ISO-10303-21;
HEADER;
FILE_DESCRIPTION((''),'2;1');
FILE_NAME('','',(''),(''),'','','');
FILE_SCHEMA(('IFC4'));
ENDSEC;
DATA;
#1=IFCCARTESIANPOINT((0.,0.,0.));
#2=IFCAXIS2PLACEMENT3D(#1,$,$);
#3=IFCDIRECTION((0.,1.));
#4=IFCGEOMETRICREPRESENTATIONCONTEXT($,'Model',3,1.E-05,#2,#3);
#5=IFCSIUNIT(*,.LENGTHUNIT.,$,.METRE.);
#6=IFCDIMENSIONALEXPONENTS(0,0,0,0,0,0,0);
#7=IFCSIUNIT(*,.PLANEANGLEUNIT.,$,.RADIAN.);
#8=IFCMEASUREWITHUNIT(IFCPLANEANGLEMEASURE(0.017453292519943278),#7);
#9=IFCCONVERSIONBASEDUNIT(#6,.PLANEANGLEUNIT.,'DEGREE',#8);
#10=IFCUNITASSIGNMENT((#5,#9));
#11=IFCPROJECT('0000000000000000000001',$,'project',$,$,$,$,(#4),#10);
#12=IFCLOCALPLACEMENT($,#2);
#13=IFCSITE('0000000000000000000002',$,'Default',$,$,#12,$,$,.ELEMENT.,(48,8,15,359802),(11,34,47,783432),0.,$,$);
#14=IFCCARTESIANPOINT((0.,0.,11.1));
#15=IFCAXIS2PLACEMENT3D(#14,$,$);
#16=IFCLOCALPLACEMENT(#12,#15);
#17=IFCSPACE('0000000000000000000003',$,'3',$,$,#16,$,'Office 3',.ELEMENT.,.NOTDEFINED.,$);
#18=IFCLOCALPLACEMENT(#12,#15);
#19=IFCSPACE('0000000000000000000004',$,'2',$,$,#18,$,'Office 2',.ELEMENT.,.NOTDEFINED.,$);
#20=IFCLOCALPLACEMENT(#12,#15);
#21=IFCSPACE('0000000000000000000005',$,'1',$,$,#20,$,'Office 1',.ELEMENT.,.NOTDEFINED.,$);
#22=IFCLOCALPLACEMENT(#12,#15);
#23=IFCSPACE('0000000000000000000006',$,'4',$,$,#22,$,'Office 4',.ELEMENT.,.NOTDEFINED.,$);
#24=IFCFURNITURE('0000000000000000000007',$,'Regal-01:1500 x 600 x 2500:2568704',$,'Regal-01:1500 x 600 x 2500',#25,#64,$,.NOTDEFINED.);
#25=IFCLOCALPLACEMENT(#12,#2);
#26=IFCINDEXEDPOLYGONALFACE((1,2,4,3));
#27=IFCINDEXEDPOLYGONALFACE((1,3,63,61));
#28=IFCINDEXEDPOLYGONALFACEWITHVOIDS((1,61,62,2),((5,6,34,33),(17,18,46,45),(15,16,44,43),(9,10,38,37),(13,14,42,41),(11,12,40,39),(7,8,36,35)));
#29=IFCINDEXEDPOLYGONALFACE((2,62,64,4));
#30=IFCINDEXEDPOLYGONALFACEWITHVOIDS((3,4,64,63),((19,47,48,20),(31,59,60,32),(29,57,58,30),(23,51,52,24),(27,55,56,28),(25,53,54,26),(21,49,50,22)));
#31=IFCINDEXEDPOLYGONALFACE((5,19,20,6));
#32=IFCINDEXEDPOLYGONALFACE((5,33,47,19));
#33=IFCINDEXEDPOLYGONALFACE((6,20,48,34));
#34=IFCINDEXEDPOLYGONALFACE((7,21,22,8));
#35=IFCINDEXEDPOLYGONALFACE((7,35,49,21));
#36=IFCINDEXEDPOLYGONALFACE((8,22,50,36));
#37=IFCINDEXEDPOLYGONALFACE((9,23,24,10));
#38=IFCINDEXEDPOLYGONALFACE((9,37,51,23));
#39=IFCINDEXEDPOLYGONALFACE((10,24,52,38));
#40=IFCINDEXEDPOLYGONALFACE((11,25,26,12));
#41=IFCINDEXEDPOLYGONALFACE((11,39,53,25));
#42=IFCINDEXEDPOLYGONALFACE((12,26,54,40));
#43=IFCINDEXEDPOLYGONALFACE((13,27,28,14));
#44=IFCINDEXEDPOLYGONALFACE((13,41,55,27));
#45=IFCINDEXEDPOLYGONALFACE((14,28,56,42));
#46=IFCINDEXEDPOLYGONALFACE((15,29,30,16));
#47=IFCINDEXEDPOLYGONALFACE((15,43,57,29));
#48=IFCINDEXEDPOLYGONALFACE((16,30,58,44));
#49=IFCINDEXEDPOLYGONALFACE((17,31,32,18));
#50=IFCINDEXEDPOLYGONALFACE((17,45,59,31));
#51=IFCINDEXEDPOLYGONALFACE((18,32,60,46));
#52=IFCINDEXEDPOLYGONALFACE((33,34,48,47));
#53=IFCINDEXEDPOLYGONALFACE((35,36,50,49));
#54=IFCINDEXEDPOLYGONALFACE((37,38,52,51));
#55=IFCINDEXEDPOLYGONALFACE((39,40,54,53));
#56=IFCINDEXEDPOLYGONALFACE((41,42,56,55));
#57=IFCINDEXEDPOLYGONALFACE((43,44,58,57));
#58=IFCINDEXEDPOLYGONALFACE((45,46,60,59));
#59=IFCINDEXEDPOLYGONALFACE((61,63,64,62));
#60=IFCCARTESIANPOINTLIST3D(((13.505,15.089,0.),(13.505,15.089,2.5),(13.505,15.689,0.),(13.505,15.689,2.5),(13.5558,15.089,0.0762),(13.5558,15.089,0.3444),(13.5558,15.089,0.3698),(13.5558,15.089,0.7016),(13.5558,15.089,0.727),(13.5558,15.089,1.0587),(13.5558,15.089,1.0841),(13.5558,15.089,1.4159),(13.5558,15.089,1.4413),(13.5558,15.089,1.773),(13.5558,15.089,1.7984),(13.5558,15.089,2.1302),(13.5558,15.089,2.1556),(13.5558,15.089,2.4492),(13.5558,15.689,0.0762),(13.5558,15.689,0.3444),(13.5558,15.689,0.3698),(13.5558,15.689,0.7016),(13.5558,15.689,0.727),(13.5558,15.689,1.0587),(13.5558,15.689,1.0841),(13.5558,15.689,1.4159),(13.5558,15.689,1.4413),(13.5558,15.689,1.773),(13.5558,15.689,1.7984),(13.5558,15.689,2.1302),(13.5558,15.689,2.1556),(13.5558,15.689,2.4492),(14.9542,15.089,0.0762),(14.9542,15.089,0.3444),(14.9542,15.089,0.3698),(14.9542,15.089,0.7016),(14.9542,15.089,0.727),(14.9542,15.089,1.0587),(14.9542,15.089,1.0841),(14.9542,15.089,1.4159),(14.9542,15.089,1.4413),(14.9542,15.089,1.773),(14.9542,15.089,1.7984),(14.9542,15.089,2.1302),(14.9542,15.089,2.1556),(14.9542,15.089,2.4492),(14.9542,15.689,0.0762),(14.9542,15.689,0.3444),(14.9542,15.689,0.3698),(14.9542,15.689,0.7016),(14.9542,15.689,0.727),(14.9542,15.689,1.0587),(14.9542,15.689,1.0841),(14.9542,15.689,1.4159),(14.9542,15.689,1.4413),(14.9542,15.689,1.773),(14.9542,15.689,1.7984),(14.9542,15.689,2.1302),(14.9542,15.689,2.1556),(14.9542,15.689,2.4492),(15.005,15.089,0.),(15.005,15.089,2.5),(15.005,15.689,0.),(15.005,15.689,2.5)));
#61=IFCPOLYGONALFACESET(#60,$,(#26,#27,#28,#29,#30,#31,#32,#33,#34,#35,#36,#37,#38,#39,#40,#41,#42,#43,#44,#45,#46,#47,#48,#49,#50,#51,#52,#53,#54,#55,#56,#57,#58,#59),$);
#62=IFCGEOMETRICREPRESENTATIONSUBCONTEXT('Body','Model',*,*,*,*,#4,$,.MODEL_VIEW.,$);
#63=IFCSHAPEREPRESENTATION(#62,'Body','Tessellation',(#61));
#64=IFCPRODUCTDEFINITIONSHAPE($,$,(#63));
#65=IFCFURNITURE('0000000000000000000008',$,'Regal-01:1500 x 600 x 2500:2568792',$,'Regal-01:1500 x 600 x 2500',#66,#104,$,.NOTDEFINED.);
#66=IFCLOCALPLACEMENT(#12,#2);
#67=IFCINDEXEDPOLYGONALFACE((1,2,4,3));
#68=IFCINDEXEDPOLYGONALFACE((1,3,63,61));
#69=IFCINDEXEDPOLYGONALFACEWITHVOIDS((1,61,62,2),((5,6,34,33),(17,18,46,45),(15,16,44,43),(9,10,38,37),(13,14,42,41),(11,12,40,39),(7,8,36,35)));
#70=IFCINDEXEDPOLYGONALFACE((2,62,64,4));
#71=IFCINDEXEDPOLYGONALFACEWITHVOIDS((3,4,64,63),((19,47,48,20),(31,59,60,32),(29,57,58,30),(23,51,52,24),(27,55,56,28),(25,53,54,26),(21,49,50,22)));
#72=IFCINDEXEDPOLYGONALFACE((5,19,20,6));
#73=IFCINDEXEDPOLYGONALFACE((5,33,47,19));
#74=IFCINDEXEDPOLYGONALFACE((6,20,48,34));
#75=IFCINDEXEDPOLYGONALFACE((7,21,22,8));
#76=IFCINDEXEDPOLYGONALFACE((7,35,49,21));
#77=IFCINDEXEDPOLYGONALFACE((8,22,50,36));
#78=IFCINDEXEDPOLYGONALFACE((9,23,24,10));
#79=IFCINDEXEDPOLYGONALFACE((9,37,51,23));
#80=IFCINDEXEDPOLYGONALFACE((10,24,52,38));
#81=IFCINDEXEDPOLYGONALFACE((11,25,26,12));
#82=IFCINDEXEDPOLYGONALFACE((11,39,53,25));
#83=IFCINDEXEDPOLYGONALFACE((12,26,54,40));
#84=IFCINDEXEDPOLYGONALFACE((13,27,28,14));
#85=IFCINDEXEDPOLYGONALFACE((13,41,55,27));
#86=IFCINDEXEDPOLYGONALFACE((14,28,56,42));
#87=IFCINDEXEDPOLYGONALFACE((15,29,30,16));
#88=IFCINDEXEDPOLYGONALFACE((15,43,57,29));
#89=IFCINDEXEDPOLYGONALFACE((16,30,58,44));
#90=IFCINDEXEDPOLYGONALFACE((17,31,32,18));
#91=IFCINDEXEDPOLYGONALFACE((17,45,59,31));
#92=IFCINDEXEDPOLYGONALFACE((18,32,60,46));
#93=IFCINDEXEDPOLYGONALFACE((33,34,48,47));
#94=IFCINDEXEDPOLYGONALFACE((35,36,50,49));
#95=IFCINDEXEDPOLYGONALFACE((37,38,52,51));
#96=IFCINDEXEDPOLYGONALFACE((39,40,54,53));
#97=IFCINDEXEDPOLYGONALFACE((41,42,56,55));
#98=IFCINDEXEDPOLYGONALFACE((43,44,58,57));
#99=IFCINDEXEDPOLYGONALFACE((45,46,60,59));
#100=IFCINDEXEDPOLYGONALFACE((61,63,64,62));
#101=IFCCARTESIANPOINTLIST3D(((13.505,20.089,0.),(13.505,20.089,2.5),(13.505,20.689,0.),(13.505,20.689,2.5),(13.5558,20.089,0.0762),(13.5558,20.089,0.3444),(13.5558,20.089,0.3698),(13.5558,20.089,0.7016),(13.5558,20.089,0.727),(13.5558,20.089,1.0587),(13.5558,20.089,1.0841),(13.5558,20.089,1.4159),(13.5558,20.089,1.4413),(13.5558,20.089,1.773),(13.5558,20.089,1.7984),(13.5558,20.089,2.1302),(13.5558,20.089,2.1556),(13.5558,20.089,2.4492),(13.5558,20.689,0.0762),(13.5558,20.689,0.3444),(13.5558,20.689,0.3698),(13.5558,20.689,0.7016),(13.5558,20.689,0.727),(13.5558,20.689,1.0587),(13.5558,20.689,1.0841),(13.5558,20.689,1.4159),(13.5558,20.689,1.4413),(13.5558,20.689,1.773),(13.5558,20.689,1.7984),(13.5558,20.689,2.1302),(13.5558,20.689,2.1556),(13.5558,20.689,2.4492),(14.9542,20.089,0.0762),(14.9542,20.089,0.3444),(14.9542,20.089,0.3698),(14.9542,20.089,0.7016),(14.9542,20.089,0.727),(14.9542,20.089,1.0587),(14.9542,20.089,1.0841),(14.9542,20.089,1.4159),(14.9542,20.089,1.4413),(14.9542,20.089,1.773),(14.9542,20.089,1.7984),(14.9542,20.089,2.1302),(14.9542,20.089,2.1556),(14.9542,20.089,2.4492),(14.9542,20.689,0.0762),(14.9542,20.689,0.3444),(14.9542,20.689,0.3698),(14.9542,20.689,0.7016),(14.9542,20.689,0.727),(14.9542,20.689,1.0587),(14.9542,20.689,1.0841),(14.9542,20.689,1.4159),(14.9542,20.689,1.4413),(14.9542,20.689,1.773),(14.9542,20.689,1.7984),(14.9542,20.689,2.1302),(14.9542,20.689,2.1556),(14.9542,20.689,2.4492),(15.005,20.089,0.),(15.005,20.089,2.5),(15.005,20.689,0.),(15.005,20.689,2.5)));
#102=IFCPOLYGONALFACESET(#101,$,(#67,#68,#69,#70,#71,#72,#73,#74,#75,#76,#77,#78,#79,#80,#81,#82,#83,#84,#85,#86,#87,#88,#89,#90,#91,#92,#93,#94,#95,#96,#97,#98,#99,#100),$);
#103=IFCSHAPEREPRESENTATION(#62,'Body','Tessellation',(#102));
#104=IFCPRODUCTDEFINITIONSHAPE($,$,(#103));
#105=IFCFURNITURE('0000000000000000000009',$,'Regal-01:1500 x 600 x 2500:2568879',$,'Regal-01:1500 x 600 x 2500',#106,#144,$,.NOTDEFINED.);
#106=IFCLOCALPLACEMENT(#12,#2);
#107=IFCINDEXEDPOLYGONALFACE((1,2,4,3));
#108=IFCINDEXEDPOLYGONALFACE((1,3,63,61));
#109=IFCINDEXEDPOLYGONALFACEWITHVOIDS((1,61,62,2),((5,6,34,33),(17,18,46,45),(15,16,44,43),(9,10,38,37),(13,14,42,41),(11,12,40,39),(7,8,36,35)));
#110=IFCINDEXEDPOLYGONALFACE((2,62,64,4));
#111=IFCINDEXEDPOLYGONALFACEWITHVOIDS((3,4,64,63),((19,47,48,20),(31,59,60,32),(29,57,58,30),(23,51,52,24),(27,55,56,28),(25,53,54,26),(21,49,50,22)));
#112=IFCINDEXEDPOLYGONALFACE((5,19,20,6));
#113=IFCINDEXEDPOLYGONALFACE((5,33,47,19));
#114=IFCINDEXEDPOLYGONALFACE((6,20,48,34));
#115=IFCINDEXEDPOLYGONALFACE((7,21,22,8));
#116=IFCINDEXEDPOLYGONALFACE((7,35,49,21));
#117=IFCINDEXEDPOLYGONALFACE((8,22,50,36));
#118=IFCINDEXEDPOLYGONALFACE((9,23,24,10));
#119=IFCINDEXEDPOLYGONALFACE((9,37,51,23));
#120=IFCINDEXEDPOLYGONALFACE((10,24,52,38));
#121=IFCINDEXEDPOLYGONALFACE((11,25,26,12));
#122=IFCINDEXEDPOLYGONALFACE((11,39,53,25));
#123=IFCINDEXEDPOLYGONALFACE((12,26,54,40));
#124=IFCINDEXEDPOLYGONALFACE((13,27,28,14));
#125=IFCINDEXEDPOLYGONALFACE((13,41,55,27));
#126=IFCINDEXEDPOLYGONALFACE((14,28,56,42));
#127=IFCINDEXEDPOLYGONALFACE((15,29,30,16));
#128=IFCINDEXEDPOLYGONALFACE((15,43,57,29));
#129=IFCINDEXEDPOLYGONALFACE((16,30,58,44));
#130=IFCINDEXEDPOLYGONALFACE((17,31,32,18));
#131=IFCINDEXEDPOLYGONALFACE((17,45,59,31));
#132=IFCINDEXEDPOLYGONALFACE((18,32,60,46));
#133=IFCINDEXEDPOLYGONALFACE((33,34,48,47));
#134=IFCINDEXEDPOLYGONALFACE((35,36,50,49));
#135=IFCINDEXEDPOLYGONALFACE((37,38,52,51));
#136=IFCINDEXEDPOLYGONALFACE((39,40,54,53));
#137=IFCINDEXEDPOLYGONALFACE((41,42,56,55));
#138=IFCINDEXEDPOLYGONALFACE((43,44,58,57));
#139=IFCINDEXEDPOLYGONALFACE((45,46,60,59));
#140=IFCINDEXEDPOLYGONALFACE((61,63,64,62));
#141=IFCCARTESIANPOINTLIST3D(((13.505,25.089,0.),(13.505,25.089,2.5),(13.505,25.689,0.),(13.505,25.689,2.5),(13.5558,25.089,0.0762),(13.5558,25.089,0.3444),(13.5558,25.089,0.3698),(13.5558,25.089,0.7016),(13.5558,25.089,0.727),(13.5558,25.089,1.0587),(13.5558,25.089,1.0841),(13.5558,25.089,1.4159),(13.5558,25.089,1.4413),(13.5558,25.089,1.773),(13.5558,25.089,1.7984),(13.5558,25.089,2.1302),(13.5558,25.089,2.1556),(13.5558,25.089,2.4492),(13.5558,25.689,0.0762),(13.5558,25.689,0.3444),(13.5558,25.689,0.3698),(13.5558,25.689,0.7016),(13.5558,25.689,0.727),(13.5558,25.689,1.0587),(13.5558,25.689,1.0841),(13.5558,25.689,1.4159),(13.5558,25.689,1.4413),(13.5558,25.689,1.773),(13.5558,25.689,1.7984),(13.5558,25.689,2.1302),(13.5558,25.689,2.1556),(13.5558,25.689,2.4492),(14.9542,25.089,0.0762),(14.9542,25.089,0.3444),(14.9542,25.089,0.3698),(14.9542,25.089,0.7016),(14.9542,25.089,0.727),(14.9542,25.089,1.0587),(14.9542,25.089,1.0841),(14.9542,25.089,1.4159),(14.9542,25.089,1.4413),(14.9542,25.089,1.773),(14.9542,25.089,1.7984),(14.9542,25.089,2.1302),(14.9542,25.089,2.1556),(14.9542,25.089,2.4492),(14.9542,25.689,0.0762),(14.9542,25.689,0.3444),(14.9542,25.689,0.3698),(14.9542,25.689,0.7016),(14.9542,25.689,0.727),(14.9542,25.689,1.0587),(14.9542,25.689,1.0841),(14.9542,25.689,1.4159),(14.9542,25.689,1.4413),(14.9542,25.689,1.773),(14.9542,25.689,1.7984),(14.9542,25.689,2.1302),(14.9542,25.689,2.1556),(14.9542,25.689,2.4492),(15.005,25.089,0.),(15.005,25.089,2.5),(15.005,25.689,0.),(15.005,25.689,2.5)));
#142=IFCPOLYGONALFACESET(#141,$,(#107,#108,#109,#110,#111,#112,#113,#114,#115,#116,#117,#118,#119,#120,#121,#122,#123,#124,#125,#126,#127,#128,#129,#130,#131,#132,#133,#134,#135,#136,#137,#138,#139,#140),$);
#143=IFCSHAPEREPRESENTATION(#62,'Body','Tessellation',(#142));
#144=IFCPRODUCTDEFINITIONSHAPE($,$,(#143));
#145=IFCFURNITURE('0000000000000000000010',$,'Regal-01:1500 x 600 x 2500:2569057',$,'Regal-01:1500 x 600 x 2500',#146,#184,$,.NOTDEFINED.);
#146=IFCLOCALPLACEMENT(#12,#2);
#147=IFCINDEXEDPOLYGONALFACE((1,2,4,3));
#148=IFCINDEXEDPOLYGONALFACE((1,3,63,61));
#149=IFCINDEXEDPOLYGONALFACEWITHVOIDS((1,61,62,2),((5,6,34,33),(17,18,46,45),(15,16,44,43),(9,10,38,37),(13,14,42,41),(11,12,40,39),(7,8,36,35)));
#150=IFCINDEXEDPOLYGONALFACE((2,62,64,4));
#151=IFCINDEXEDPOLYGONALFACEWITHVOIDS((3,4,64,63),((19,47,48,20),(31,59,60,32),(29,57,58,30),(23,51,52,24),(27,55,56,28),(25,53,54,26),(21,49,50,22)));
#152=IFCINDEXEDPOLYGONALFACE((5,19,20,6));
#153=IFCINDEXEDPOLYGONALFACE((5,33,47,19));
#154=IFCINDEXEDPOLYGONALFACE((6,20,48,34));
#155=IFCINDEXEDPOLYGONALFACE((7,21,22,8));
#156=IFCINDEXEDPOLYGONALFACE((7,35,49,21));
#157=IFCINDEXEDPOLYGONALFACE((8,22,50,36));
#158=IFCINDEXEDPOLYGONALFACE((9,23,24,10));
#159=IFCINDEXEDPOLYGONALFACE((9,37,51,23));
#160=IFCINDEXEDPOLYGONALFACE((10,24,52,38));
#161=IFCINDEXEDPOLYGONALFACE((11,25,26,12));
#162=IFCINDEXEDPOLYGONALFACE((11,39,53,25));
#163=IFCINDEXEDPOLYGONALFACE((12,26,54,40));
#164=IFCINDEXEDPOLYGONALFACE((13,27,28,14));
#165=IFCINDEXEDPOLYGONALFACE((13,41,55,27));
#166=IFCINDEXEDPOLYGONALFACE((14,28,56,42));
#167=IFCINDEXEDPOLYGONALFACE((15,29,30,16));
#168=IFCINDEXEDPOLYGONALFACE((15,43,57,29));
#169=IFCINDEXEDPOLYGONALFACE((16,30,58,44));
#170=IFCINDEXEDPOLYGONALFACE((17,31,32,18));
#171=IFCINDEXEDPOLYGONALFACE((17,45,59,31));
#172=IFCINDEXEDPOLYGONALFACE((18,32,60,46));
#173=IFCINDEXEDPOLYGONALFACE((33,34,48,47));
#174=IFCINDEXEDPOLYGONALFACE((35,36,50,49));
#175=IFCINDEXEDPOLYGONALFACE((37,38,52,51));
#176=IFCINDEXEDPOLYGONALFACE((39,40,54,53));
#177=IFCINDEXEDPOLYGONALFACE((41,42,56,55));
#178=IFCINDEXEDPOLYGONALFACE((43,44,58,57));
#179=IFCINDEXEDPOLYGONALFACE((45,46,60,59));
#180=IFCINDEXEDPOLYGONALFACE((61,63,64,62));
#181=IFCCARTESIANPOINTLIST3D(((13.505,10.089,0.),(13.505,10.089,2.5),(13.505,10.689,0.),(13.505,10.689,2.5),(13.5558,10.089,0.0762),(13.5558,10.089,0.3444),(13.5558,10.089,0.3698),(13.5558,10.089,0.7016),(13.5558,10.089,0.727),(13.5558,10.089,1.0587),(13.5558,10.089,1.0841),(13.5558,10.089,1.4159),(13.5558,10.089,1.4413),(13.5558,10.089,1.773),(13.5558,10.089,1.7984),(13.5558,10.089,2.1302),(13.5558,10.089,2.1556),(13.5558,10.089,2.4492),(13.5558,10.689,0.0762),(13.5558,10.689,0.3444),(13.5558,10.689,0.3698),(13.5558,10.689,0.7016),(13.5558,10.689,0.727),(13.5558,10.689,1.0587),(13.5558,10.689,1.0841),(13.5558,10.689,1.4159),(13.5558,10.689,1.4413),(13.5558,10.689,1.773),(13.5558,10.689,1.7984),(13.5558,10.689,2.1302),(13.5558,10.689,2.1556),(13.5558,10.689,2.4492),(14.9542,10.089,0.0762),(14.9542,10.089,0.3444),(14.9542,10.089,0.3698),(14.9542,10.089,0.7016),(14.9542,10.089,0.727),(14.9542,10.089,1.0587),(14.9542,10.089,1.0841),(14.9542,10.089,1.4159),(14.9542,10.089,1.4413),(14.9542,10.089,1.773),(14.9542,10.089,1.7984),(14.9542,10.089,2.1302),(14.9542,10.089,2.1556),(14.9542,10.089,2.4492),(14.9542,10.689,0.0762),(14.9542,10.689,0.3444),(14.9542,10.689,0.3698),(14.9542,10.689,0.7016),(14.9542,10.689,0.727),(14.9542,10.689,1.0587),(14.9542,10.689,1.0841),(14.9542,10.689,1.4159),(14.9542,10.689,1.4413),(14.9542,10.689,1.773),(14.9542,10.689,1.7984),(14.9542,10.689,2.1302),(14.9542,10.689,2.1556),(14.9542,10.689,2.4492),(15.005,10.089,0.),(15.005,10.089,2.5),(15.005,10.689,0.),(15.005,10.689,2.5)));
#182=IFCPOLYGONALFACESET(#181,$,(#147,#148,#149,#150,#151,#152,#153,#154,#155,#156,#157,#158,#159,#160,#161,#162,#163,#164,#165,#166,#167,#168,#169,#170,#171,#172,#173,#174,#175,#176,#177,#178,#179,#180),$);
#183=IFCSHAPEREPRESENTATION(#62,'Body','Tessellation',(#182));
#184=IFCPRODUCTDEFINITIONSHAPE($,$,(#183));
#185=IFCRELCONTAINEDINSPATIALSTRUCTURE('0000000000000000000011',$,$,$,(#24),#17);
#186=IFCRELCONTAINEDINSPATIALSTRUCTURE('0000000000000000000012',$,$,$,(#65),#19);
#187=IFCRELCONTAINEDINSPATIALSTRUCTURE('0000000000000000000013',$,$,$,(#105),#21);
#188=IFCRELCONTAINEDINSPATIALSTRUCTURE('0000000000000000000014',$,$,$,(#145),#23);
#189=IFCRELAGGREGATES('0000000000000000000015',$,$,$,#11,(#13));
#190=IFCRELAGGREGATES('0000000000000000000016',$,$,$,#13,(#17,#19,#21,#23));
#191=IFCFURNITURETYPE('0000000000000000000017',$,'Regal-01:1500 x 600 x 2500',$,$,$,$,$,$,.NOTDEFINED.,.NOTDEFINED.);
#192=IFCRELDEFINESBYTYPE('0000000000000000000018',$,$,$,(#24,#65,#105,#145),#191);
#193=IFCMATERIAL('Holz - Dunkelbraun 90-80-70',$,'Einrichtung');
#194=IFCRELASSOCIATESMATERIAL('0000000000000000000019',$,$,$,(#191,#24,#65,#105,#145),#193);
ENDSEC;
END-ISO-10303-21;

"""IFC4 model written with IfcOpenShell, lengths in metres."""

from ifc_helpers import new_model, entity, si_unit, converted_unit, direction, frame, origin, place, context, subcontext, project, spatial, indexed_curve, outline, extrude, source, transform, mapped, material, type_object, type_shapes, element, save


model = new_model("IFC4")

# Units and contexts
model_context = context("Model", 3, precision=1e-05, world=origin(), true_north=direction((0.0, 1.0)))
body_context = subcontext(model_context, "Body", "Model", "MODEL_VIEW")
ifc_project = project(units=[si_unit("LENGTHUNIT", "METRE"), converted_unit("PLANEANGLEUNIT", "DEGREE", entity("IfcPlaneAngleMeasure", 0.017453292519943278), si_unit("PLANEANGLEUNIT", "RADIAN"), dimensions=[0, 0, 0, 0, 0, 0, 0])], contexts=[model_context])

# Site, space
site_placement = place(None, origin())
site = spatial("IfcSite", under=ifc_project, at=site_placement, Name="Default", CompositionType="ELEMENT", RefLatitude=(48, 8, 15, 359802), RefLongitude=(11, 34, 47, 783432), RefElevation=0.0)
space_1_placement = place(site_placement, frame((0.0, 0.0, 11.1)))
space_1 = spatial("IfcSpace", under=site, at=space_1_placement, Name="3", LongName="Office 3", CompositionType="ELEMENT", PredefinedType="NOTDEFINED")

# Furniture
ifc_material = material(Name="Holz - Dunkelbraun 90-80-70", Category="Einrichtung")
furniture_type = type_object("IfcFurnitureType", Name="Regal-01:1500 x 600 x 2500", AssemblyPlace="NOTDEFINED", PredefinedType="NOTDEFINED", material=ifc_material)
shared_shape = source(origin(), body_context, "Body", "SweptSolid", [
    extrude(outline(indexed_curve([(-0.75, -1.25), (0.75, -1.25), (0.75, 1.25), (-0.75, 1.25), (-0.75, -1.25)], self_intersect=False), holes=[indexed_curve([(-0.6992, 1.1992), (0.6992, 1.1992), (0.6992, 0.9056), (-0.6992, 0.9056), (-0.6992, 1.1992)], self_intersect=False), indexed_curve([(-0.6992, -1.1738), (-0.6992, -0.9056), (0.6992, -0.9056), (0.6992, -1.1738), (-0.6992, -1.1738)], self_intersect=False), indexed_curve([(0.6992, 0.1913), (-0.6992, 0.1913), (-0.6992, 0.523), (0.6992, 0.523), (0.6992, 0.1913)], self_intersect=False), indexed_curve([(0.6992, -0.5484), (0.6992, -0.8802), (-0.6992, -0.8802), (-0.6992, -0.5484), (0.6992, -0.5484)], self_intersect=False), indexed_curve([(-0.6992, 0.8802), (0.6992, 0.8802), (0.6992, 0.5484), (-0.6992, 0.5484), (-0.6992, 0.8802)], self_intersect=False), indexed_curve([(-0.6992, 0.1659), (0.6992, 0.1659), (0.6992, -0.1659), (-0.6992, -0.1659), (-0.6992, 0.1659)], self_intersect=False), indexed_curve([(-0.6992, -0.1913), (0.6992, -0.1913), (0.6992, -0.523), (-0.6992, -0.523), (-0.6992, -0.1913)], self_intersect=False)]), frame((0.0, -0.6048, 1.25), z_axis=(0.0, 1.0, 0.0), x_axis=(-1.0, 0.0, 0.0)), (0.0, 0.0, 1.0), 0.6),
])
type_shapes(furniture_type, [shared_shape])
furniture_1_placement = place(space_1_placement, frame((14.255, 15.6938, -11.1)))
element("IfcFurniture", 1, at=furniture_1_placement, inside=space_1, type_object=furniture_type, material=ifc_material, Name="Regal-01:1500 x 600 x 2500:2568704", ObjectType="Regal-01:1500 x 600 x 2500", PredefinedType="NOTDEFINED", context=body_context, shape_type="MappedRepresentation", body=[
    mapped(shared_shape, transform((0.0, 0.0, 0.0), scale=1.0)),
])

# Shared definitions
space_2_placement = place(site_placement, frame((0.0, 0.0, 11.1)))
space_2 = spatial("IfcSpace", under=site, at=space_2_placement, Name="2", LongName="Office 2", CompositionType="ELEMENT", PredefinedType="NOTDEFINED")

# Furniture
furniture_2_placement = place(space_2_placement, frame((14.255, 20.6938, -11.1)))
element("IfcFurniture", 2, at=furniture_2_placement, inside=space_2, type_object=furniture_type, material=ifc_material, Name="Regal-01:1500 x 600 x 2500:2568792", ObjectType="Regal-01:1500 x 600 x 2500", PredefinedType="NOTDEFINED", context=body_context, shape_type="MappedRepresentation", body=[
    mapped(shared_shape, transform((0.0, 0.0, 0.0), scale=1.0)),
])

# Shared definitions
space_3_placement = place(site_placement, frame((0.0, 0.0, 11.1)))
space_3 = spatial("IfcSpace", under=site, at=space_3_placement, Name="1", LongName="Office 1", CompositionType="ELEMENT", PredefinedType="NOTDEFINED")

# Furniture
furniture_3_placement = place(space_3_placement, frame((14.255, 25.6938, -11.1)))
element("IfcFurniture", 3, at=furniture_3_placement, inside=space_3, type_object=furniture_type, material=ifc_material, Name="Regal-01:1500 x 600 x 2500:2568879", ObjectType="Regal-01:1500 x 600 x 2500", PredefinedType="NOTDEFINED", context=body_context, shape_type="MappedRepresentation", body=[
    mapped(shared_shape, transform((0.0, 0.0, 0.0), scale=1.0)),
])

# Shared definitions
space_4_placement = place(site_placement, frame((0.0, 0.0, 11.1)))
space_4 = spatial("IfcSpace", under=site, at=space_4_placement, Name="4", LongName="Office 4", CompositionType="ELEMENT", PredefinedType="NOTDEFINED")

# Furniture
furniture_4_placement = place(space_4_placement, frame((14.255, 10.6938, -11.1)))
element("IfcFurniture", 4, at=furniture_4_placement, inside=space_4, type_object=furniture_type, material=ifc_material, Name="Regal-01:1500 x 600 x 2500:2569057", ObjectType="Regal-01:1500 x 600 x 2500", PredefinedType="NOTDEFINED", context=body_context, shape_type="MappedRepresentation", body=[
    mapped(shared_shape, transform((0.0, 0.0, 0.0), scale=1.0)),
])

save(model, "model.ifc")
